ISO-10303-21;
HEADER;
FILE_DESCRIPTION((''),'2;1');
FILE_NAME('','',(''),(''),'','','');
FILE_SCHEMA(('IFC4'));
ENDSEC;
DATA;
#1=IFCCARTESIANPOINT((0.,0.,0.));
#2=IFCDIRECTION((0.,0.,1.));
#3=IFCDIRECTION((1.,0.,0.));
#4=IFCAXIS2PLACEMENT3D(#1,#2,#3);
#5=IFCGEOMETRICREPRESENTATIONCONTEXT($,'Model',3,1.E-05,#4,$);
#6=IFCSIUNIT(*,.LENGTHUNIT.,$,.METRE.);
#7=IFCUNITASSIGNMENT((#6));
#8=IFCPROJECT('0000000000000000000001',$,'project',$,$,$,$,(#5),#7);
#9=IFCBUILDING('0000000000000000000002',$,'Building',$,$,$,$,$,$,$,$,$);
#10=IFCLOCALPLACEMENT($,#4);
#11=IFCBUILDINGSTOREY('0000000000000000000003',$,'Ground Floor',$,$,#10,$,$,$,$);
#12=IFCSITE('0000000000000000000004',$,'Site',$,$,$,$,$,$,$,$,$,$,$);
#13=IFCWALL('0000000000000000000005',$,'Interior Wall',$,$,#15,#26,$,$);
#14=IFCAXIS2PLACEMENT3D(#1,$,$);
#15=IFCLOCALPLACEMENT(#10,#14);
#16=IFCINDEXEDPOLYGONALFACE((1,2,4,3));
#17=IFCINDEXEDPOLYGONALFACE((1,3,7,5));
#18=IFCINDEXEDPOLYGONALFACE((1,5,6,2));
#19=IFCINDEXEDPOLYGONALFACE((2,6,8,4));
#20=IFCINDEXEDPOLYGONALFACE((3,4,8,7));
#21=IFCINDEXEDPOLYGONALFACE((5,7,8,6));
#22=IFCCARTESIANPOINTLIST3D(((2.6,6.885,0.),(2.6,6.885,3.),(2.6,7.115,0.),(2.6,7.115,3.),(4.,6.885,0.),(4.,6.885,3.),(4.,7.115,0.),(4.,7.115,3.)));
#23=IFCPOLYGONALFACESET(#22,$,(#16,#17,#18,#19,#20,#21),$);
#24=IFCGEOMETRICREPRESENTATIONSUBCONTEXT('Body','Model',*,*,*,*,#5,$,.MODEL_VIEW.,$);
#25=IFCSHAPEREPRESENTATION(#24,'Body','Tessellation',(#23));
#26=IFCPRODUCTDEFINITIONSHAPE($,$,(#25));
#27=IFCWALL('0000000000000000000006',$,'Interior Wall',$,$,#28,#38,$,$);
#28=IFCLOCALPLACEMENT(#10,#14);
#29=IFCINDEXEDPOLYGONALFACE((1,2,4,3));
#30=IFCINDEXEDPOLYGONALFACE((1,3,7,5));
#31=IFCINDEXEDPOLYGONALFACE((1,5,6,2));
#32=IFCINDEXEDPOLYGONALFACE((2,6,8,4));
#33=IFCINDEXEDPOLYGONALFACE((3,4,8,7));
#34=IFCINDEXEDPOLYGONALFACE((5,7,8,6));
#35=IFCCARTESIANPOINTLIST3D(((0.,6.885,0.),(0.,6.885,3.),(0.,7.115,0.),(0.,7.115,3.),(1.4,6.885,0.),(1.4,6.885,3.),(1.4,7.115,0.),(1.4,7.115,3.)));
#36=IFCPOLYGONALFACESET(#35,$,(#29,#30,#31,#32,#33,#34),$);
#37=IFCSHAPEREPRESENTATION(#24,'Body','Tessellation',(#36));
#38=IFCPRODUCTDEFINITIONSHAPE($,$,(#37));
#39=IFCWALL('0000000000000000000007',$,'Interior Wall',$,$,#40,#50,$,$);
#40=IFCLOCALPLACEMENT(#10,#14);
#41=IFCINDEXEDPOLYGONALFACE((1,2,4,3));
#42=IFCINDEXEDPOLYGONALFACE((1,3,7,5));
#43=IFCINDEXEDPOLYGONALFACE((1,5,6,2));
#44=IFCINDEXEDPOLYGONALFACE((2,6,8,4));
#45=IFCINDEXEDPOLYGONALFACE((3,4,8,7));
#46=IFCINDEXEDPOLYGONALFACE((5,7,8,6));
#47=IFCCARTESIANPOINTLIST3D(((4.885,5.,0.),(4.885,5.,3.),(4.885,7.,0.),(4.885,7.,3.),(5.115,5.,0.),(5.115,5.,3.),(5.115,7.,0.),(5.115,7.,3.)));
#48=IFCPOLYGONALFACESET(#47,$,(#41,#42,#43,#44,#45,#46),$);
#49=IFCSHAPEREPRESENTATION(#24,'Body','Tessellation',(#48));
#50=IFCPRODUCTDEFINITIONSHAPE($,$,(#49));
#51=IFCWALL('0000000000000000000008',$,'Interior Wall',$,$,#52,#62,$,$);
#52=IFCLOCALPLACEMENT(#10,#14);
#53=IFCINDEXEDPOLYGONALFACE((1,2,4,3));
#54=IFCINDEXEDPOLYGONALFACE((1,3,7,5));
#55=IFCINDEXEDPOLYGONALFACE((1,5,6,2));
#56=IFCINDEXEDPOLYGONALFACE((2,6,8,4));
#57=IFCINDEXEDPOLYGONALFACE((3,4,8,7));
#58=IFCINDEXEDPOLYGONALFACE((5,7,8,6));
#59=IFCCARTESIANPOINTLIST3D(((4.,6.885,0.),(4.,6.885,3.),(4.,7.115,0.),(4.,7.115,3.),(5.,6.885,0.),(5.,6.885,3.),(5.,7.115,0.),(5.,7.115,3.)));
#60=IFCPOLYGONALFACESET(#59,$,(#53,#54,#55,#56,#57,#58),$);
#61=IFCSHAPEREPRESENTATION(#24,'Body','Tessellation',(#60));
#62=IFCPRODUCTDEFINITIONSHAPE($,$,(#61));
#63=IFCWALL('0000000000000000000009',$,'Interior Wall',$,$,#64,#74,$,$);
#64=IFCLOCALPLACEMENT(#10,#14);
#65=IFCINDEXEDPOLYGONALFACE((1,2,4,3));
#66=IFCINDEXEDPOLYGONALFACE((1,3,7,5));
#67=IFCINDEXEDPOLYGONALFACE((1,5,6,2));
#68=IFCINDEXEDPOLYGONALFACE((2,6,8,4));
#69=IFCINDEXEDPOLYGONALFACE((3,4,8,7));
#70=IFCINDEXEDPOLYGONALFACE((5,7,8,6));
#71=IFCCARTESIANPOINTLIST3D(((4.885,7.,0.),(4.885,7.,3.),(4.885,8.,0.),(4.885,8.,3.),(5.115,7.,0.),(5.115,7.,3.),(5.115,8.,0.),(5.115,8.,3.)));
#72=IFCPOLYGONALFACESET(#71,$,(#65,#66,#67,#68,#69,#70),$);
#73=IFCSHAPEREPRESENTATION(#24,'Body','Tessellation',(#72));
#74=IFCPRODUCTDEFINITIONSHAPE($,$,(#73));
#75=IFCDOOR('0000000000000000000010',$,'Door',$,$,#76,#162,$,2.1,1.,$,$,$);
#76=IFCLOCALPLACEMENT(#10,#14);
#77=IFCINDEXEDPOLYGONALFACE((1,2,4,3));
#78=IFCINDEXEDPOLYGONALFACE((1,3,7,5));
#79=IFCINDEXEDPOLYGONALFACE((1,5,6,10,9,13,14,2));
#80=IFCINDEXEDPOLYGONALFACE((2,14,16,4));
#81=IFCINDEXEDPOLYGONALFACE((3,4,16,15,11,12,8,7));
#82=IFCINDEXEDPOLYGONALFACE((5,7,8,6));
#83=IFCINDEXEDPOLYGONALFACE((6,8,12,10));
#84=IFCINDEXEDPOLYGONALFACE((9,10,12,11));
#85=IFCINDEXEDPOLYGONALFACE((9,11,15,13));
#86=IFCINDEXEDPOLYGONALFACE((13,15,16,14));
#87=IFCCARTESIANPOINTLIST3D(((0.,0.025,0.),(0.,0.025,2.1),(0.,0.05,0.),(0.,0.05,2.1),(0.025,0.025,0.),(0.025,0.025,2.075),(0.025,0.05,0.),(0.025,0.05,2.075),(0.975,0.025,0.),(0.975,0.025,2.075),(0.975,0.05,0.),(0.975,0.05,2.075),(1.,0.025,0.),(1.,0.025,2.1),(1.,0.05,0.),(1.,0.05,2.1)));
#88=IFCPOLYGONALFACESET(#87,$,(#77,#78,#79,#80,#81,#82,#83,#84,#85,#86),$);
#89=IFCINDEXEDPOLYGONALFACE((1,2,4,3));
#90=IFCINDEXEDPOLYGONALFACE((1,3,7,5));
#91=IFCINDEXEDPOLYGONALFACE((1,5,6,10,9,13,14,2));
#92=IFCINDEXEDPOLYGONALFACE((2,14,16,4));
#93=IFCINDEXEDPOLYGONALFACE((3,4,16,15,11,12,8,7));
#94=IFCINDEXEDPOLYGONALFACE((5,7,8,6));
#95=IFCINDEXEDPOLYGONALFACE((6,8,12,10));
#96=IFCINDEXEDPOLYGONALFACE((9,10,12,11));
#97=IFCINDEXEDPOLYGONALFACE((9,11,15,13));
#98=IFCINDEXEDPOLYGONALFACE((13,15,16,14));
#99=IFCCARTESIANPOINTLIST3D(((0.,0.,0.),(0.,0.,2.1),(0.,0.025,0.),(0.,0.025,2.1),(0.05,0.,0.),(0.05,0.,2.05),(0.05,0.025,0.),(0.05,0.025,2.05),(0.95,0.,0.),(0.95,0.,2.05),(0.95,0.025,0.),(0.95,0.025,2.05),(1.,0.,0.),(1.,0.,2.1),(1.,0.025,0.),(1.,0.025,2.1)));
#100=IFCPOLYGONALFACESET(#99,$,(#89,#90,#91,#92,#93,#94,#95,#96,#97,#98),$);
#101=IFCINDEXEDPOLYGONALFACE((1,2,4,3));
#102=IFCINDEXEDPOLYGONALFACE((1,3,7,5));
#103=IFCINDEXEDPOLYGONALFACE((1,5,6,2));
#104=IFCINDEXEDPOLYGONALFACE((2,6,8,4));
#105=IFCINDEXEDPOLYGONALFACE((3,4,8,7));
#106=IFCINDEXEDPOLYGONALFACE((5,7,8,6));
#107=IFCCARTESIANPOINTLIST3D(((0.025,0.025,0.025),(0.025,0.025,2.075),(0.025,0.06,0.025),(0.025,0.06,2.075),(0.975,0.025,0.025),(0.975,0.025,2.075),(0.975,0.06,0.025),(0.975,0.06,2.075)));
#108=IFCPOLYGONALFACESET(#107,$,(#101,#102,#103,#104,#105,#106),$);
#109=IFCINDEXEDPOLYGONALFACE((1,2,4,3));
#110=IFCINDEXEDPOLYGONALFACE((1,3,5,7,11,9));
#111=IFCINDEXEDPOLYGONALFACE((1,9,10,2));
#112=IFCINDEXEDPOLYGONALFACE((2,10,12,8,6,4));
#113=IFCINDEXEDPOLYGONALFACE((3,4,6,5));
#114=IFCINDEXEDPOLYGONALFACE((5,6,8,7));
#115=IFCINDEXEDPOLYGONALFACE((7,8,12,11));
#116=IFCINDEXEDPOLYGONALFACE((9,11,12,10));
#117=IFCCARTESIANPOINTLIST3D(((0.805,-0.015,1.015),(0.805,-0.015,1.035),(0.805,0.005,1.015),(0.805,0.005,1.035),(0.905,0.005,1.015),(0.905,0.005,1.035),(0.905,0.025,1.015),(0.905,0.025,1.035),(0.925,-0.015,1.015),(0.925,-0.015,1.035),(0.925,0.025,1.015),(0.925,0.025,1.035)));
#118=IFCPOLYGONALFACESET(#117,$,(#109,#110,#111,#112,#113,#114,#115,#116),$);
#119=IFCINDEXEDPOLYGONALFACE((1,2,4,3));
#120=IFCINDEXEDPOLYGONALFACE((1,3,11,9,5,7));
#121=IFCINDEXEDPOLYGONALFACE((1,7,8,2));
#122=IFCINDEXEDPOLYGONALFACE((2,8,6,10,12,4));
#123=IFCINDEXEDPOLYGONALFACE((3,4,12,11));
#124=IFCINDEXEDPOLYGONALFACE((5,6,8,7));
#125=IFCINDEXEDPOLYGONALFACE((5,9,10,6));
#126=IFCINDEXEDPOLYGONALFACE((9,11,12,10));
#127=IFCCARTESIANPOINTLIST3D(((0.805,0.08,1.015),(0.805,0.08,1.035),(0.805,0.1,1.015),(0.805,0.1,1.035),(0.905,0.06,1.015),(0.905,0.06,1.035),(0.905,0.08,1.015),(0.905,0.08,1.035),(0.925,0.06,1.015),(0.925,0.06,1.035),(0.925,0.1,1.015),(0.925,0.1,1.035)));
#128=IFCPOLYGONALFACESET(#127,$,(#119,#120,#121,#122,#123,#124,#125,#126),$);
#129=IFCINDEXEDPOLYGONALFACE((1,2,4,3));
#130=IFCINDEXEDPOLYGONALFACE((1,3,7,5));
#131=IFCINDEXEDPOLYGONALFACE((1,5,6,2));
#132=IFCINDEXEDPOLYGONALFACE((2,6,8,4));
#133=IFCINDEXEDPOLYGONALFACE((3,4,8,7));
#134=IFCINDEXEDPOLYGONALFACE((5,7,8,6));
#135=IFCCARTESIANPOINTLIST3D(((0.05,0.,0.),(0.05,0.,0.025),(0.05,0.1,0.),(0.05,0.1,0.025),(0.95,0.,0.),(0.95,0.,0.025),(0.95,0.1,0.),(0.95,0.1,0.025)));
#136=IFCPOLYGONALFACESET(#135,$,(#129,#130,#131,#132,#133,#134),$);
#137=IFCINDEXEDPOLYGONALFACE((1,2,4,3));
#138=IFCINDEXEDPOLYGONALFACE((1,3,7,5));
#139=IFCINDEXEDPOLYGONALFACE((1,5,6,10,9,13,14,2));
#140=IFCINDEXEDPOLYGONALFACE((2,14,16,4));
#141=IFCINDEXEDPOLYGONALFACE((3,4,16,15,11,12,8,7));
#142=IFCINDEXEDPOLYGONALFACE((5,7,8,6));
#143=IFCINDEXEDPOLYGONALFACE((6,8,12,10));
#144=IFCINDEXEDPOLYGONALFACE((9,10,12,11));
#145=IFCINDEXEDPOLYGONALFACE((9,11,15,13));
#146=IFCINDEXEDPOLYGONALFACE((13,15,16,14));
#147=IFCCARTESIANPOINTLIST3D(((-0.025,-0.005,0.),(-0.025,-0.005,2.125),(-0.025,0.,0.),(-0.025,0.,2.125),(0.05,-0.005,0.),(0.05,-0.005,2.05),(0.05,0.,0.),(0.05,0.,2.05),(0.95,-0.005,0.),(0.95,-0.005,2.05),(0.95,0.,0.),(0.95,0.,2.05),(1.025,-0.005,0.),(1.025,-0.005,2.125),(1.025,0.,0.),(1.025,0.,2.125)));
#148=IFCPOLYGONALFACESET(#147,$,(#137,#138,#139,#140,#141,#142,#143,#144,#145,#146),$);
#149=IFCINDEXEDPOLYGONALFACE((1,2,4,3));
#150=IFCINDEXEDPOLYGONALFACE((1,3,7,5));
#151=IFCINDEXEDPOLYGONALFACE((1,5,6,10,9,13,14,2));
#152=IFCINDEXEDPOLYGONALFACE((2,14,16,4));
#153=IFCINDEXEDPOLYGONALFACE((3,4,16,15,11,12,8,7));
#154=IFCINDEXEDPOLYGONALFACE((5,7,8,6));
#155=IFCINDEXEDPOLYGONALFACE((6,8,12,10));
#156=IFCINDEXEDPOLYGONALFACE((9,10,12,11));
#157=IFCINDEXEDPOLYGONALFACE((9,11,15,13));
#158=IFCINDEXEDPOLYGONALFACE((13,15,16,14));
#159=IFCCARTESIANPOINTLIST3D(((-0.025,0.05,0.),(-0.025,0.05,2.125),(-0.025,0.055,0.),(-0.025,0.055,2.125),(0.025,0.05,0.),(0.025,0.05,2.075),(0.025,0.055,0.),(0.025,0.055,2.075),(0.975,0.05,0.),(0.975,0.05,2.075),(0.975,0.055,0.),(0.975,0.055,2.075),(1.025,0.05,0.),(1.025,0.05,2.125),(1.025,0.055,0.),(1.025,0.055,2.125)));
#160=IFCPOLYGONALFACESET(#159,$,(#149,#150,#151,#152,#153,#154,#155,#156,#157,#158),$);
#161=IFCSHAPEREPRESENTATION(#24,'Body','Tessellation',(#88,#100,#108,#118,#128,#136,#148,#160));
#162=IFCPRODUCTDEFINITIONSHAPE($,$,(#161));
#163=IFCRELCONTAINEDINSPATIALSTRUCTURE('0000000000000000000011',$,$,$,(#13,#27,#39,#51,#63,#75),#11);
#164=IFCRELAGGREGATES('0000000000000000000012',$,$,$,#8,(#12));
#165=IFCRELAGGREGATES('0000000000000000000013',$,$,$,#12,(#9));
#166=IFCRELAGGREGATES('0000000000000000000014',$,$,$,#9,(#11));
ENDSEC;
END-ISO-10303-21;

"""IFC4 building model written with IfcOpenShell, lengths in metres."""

from ifc_helpers import new_model, si_unit, frame, origin_with_axes, place, context, subcontext, project, spatial, line, indexed_curve, outline, extrude, element, save


model = new_model("IFC4")

# Units and contexts
model_context = context("Model", 3, precision=1e-05, world=origin_with_axes())
body_context = subcontext(model_context, "Body", "Model", "MODEL_VIEW")
ifc_project = project(units=[si_unit("LENGTHUNIT", "METRE")], contexts=[model_context])

# Site, building, storey
site = spatial("IfcSite", under=ifc_project, Name="Site")
building = spatial("IfcBuilding", under=site, Name="Building")
storey_placement = place(None, origin_with_axes())
storey = spatial("IfcBuildingStorey", under=building, at=storey_placement, Name="Ground Floor")

# Walls
for number, where, z_axis, x_axis, name in (
    (1, (4.0, 7.0, 0.0), (0.0, 0.0, 1.0), (-1.0, 0.0, 0.0), "Interior Wall"),
    (2, (1.4, 7.0, 0.0), (0.0, 0.0, 1.0), (-1.0, 0.0, 0.0), "Interior Wall"),
):
    element("IfcWall", number, at=place(storey_placement, frame(where, z_axis=z_axis, x_axis=x_axis)), inside=storey, Name=name, context=body_context, shape_type="SweptSolid", body=[
        extrude(outline(indexed_curve([(0.0, 0.0), (0.0, 0.23), (1.4, 0.23), (1.4, 0.0), (0.0, 0.0)], self_intersect=False)), frame((0.0, -0.115, 0.0), z_axis=(0.0, 0.0, 1.0), x_axis=(1.0, 0.0, 0.0)), (0.0, 0.0, 1.0), 3.0),
    ])
wall_1_placement = place(storey_placement, frame((5.0, 5.0, 0.0), z_axis=(0.0, 0.0, 1.0), x_axis=(0.0, 1.0, 0.0)))
element("IfcWall", 3, at=wall_1_placement, inside=storey, Name="Interior Wall", context=body_context, shape_type="SweptSolid", body=[
    extrude(outline(indexed_curve([(0.0, 0.0), (0.0, 0.23), (2.0, 0.23), (2.0, 0.0), (0.0, 0.0)], self_intersect=False)), frame((0.0, -0.115, 0.0), z_axis=(0.0, 0.0, 1.0), x_axis=(1.0, 0.0, 0.0)), (0.0, 0.0, 1.0), 3.0),
])
for number, where, z_axis, x_axis, name in (
    (4, (5.0, 7.0, 0.0), (0.0, 0.0, 1.0), (-1.0, 0.0, 0.0), "Interior Wall"),
    (5, (5.0, 8.0, 0.0), (0.0, 0.0, 1.0), (0.0, -1.0, 0.0), "Interior Wall"),
):
    element("IfcWall", number, at=place(storey_placement, frame(where, z_axis=z_axis, x_axis=x_axis)), inside=storey, Name=name, context=body_context, shape_type="SweptSolid", body=[
        extrude(outline(indexed_curve([(0.0, 0.0), (0.0, 0.23), (1.0, 0.23), (1.0, 0.0), (0.0, 0.0)], self_intersect=False)), frame((0.0, -0.115, 0.0), z_axis=(0.0, 0.0, 1.0), x_axis=(1.0, 0.0, 0.0)), (0.0, 0.0, 1.0), 3.0),
    ])

# Door
door_1_placement = place(storey_placement, origin_with_axes())
element("IfcDoor", 6, at=door_1_placement, inside=storey, Name="Door", OverallHeight=2.1, OverallWidth=1.0, context=body_context, shape_type="SweptSolid", body=[
    extrude(outline(indexed_curve([(0.0, 0.0), (0.0, 2.1), (1.0, 2.1), (1.0, 0.0), (0.975, 0.0), (0.975, 2.075), (0.025, 2.075), (0.025, 0.0)], segments=[line(1, 2, 3, 4, 5, 6, 7, 8, 1)])), frame((0.0, 0.025, 0.0), z_axis=(0.0, -1.0, 0.0), x_axis=(1.0, 0.0, 0.0)), (0.0, 0.0, -1.0), 0.025),
    extrude(outline(indexed_curve([(0.0, 0.0), (0.0, 2.1), (1.0, 2.1), (1.0, 0.0), (0.95, 0.0), (0.95, 2.05), (0.05, 2.05), (0.05, 0.0)], segments=[line(1, 2, 3, 4, 5, 6, 7, 8, 1)])), frame((0.0, 0.0, 0.0), z_axis=(0.0, -1.0, 0.0), x_axis=(1.0, 0.0, 0.0)), (0.0, 0.0, -1.0), 0.025),
    extrude(outline(indexed_curve([(0.0, 0.0), (0.95, 0.0), (0.95, 0.035), (0.0, 0.035)], segments=[line(1, 2, 3, 4, 1)])), frame((0.025, 0.025, 0.025), z_axis=(0.0, 0.0, 1.0), x_axis=(1.0, 0.0, 0.0)), (0.0, 0.0, 1.0), 2.05),
    extrude(outline(indexed_curve([(0.0, 0.0), (0.0, -0.04), (-0.12, -0.04), (-0.12, -0.02), (-0.02, -0.02), (-0.02, 0.0)], segments=[line(1, 2, 3, 4, 5, 6, 1)])), frame((0.925, 0.025, 1.015), z_axis=(0.0, 0.0, 1.0), x_axis=(1.0, 0.0, 0.0)), (0.0, 0.0, 1.0), 0.02),
    extrude(outline(indexed_curve([(0.0, 0.0), (0.0, 0.04), (-0.12, 0.04), (-0.12, 0.02), (-0.02, 0.02), (-0.02, 0.0)], segments=[line(1, 2, 3, 4, 5, 6, 1)])), frame((0.925, 0.06, 1.015), z_axis=(0.0, 0.0, 1.0), x_axis=(1.0, 0.0, 0.0)), (0.0, 0.0, 1.0), 0.02),
    extrude(outline(indexed_curve([(0.0, 0.0), (0.9, 0.0), (0.9, 0.1), (0.0, 0.1)], segments=[line(1, 2, 3, 4, 1)])), frame((0.05, 0.0, 0.0), z_axis=(0.0, 0.0, 1.0), x_axis=(1.0, 0.0, 0.0)), (0.0, 0.0, 1.0), 0.025),
    extrude(outline(indexed_curve([(0.0, 0.0), (0.0, 2.125), (1.05, 2.125), (1.05, 0.0), (0.975, 0.0), (0.975, 2.05), (0.075, 2.05), (0.075, 0.0)], segments=[line(1, 2, 3, 4, 5, 6, 7, 8, 1)])), frame((-0.025, -0.005, 0.0), z_axis=(0.0, -1.0, 0.0), x_axis=(1.0, 0.0, 0.0)), (0.0, 0.0, -1.0), 0.005),
    extrude(outline(indexed_curve([(0.0, 0.0), (0.0, 2.125), (1.05, 2.125), (1.05, 0.0), (1.0, 0.0), (1.0, 2.075), (0.05, 2.075), (0.05, 0.0)], segments=[line(1, 2, 3, 4, 5, 6, 7, 8, 1)])), frame((-0.025, 0.05, 0.0), z_axis=(0.0, -1.0, 0.0), x_axis=(1.0, 0.0, 0.0)), (0.0, 0.0, -1.0), 0.005),
])

save(model, "model.ifc")
